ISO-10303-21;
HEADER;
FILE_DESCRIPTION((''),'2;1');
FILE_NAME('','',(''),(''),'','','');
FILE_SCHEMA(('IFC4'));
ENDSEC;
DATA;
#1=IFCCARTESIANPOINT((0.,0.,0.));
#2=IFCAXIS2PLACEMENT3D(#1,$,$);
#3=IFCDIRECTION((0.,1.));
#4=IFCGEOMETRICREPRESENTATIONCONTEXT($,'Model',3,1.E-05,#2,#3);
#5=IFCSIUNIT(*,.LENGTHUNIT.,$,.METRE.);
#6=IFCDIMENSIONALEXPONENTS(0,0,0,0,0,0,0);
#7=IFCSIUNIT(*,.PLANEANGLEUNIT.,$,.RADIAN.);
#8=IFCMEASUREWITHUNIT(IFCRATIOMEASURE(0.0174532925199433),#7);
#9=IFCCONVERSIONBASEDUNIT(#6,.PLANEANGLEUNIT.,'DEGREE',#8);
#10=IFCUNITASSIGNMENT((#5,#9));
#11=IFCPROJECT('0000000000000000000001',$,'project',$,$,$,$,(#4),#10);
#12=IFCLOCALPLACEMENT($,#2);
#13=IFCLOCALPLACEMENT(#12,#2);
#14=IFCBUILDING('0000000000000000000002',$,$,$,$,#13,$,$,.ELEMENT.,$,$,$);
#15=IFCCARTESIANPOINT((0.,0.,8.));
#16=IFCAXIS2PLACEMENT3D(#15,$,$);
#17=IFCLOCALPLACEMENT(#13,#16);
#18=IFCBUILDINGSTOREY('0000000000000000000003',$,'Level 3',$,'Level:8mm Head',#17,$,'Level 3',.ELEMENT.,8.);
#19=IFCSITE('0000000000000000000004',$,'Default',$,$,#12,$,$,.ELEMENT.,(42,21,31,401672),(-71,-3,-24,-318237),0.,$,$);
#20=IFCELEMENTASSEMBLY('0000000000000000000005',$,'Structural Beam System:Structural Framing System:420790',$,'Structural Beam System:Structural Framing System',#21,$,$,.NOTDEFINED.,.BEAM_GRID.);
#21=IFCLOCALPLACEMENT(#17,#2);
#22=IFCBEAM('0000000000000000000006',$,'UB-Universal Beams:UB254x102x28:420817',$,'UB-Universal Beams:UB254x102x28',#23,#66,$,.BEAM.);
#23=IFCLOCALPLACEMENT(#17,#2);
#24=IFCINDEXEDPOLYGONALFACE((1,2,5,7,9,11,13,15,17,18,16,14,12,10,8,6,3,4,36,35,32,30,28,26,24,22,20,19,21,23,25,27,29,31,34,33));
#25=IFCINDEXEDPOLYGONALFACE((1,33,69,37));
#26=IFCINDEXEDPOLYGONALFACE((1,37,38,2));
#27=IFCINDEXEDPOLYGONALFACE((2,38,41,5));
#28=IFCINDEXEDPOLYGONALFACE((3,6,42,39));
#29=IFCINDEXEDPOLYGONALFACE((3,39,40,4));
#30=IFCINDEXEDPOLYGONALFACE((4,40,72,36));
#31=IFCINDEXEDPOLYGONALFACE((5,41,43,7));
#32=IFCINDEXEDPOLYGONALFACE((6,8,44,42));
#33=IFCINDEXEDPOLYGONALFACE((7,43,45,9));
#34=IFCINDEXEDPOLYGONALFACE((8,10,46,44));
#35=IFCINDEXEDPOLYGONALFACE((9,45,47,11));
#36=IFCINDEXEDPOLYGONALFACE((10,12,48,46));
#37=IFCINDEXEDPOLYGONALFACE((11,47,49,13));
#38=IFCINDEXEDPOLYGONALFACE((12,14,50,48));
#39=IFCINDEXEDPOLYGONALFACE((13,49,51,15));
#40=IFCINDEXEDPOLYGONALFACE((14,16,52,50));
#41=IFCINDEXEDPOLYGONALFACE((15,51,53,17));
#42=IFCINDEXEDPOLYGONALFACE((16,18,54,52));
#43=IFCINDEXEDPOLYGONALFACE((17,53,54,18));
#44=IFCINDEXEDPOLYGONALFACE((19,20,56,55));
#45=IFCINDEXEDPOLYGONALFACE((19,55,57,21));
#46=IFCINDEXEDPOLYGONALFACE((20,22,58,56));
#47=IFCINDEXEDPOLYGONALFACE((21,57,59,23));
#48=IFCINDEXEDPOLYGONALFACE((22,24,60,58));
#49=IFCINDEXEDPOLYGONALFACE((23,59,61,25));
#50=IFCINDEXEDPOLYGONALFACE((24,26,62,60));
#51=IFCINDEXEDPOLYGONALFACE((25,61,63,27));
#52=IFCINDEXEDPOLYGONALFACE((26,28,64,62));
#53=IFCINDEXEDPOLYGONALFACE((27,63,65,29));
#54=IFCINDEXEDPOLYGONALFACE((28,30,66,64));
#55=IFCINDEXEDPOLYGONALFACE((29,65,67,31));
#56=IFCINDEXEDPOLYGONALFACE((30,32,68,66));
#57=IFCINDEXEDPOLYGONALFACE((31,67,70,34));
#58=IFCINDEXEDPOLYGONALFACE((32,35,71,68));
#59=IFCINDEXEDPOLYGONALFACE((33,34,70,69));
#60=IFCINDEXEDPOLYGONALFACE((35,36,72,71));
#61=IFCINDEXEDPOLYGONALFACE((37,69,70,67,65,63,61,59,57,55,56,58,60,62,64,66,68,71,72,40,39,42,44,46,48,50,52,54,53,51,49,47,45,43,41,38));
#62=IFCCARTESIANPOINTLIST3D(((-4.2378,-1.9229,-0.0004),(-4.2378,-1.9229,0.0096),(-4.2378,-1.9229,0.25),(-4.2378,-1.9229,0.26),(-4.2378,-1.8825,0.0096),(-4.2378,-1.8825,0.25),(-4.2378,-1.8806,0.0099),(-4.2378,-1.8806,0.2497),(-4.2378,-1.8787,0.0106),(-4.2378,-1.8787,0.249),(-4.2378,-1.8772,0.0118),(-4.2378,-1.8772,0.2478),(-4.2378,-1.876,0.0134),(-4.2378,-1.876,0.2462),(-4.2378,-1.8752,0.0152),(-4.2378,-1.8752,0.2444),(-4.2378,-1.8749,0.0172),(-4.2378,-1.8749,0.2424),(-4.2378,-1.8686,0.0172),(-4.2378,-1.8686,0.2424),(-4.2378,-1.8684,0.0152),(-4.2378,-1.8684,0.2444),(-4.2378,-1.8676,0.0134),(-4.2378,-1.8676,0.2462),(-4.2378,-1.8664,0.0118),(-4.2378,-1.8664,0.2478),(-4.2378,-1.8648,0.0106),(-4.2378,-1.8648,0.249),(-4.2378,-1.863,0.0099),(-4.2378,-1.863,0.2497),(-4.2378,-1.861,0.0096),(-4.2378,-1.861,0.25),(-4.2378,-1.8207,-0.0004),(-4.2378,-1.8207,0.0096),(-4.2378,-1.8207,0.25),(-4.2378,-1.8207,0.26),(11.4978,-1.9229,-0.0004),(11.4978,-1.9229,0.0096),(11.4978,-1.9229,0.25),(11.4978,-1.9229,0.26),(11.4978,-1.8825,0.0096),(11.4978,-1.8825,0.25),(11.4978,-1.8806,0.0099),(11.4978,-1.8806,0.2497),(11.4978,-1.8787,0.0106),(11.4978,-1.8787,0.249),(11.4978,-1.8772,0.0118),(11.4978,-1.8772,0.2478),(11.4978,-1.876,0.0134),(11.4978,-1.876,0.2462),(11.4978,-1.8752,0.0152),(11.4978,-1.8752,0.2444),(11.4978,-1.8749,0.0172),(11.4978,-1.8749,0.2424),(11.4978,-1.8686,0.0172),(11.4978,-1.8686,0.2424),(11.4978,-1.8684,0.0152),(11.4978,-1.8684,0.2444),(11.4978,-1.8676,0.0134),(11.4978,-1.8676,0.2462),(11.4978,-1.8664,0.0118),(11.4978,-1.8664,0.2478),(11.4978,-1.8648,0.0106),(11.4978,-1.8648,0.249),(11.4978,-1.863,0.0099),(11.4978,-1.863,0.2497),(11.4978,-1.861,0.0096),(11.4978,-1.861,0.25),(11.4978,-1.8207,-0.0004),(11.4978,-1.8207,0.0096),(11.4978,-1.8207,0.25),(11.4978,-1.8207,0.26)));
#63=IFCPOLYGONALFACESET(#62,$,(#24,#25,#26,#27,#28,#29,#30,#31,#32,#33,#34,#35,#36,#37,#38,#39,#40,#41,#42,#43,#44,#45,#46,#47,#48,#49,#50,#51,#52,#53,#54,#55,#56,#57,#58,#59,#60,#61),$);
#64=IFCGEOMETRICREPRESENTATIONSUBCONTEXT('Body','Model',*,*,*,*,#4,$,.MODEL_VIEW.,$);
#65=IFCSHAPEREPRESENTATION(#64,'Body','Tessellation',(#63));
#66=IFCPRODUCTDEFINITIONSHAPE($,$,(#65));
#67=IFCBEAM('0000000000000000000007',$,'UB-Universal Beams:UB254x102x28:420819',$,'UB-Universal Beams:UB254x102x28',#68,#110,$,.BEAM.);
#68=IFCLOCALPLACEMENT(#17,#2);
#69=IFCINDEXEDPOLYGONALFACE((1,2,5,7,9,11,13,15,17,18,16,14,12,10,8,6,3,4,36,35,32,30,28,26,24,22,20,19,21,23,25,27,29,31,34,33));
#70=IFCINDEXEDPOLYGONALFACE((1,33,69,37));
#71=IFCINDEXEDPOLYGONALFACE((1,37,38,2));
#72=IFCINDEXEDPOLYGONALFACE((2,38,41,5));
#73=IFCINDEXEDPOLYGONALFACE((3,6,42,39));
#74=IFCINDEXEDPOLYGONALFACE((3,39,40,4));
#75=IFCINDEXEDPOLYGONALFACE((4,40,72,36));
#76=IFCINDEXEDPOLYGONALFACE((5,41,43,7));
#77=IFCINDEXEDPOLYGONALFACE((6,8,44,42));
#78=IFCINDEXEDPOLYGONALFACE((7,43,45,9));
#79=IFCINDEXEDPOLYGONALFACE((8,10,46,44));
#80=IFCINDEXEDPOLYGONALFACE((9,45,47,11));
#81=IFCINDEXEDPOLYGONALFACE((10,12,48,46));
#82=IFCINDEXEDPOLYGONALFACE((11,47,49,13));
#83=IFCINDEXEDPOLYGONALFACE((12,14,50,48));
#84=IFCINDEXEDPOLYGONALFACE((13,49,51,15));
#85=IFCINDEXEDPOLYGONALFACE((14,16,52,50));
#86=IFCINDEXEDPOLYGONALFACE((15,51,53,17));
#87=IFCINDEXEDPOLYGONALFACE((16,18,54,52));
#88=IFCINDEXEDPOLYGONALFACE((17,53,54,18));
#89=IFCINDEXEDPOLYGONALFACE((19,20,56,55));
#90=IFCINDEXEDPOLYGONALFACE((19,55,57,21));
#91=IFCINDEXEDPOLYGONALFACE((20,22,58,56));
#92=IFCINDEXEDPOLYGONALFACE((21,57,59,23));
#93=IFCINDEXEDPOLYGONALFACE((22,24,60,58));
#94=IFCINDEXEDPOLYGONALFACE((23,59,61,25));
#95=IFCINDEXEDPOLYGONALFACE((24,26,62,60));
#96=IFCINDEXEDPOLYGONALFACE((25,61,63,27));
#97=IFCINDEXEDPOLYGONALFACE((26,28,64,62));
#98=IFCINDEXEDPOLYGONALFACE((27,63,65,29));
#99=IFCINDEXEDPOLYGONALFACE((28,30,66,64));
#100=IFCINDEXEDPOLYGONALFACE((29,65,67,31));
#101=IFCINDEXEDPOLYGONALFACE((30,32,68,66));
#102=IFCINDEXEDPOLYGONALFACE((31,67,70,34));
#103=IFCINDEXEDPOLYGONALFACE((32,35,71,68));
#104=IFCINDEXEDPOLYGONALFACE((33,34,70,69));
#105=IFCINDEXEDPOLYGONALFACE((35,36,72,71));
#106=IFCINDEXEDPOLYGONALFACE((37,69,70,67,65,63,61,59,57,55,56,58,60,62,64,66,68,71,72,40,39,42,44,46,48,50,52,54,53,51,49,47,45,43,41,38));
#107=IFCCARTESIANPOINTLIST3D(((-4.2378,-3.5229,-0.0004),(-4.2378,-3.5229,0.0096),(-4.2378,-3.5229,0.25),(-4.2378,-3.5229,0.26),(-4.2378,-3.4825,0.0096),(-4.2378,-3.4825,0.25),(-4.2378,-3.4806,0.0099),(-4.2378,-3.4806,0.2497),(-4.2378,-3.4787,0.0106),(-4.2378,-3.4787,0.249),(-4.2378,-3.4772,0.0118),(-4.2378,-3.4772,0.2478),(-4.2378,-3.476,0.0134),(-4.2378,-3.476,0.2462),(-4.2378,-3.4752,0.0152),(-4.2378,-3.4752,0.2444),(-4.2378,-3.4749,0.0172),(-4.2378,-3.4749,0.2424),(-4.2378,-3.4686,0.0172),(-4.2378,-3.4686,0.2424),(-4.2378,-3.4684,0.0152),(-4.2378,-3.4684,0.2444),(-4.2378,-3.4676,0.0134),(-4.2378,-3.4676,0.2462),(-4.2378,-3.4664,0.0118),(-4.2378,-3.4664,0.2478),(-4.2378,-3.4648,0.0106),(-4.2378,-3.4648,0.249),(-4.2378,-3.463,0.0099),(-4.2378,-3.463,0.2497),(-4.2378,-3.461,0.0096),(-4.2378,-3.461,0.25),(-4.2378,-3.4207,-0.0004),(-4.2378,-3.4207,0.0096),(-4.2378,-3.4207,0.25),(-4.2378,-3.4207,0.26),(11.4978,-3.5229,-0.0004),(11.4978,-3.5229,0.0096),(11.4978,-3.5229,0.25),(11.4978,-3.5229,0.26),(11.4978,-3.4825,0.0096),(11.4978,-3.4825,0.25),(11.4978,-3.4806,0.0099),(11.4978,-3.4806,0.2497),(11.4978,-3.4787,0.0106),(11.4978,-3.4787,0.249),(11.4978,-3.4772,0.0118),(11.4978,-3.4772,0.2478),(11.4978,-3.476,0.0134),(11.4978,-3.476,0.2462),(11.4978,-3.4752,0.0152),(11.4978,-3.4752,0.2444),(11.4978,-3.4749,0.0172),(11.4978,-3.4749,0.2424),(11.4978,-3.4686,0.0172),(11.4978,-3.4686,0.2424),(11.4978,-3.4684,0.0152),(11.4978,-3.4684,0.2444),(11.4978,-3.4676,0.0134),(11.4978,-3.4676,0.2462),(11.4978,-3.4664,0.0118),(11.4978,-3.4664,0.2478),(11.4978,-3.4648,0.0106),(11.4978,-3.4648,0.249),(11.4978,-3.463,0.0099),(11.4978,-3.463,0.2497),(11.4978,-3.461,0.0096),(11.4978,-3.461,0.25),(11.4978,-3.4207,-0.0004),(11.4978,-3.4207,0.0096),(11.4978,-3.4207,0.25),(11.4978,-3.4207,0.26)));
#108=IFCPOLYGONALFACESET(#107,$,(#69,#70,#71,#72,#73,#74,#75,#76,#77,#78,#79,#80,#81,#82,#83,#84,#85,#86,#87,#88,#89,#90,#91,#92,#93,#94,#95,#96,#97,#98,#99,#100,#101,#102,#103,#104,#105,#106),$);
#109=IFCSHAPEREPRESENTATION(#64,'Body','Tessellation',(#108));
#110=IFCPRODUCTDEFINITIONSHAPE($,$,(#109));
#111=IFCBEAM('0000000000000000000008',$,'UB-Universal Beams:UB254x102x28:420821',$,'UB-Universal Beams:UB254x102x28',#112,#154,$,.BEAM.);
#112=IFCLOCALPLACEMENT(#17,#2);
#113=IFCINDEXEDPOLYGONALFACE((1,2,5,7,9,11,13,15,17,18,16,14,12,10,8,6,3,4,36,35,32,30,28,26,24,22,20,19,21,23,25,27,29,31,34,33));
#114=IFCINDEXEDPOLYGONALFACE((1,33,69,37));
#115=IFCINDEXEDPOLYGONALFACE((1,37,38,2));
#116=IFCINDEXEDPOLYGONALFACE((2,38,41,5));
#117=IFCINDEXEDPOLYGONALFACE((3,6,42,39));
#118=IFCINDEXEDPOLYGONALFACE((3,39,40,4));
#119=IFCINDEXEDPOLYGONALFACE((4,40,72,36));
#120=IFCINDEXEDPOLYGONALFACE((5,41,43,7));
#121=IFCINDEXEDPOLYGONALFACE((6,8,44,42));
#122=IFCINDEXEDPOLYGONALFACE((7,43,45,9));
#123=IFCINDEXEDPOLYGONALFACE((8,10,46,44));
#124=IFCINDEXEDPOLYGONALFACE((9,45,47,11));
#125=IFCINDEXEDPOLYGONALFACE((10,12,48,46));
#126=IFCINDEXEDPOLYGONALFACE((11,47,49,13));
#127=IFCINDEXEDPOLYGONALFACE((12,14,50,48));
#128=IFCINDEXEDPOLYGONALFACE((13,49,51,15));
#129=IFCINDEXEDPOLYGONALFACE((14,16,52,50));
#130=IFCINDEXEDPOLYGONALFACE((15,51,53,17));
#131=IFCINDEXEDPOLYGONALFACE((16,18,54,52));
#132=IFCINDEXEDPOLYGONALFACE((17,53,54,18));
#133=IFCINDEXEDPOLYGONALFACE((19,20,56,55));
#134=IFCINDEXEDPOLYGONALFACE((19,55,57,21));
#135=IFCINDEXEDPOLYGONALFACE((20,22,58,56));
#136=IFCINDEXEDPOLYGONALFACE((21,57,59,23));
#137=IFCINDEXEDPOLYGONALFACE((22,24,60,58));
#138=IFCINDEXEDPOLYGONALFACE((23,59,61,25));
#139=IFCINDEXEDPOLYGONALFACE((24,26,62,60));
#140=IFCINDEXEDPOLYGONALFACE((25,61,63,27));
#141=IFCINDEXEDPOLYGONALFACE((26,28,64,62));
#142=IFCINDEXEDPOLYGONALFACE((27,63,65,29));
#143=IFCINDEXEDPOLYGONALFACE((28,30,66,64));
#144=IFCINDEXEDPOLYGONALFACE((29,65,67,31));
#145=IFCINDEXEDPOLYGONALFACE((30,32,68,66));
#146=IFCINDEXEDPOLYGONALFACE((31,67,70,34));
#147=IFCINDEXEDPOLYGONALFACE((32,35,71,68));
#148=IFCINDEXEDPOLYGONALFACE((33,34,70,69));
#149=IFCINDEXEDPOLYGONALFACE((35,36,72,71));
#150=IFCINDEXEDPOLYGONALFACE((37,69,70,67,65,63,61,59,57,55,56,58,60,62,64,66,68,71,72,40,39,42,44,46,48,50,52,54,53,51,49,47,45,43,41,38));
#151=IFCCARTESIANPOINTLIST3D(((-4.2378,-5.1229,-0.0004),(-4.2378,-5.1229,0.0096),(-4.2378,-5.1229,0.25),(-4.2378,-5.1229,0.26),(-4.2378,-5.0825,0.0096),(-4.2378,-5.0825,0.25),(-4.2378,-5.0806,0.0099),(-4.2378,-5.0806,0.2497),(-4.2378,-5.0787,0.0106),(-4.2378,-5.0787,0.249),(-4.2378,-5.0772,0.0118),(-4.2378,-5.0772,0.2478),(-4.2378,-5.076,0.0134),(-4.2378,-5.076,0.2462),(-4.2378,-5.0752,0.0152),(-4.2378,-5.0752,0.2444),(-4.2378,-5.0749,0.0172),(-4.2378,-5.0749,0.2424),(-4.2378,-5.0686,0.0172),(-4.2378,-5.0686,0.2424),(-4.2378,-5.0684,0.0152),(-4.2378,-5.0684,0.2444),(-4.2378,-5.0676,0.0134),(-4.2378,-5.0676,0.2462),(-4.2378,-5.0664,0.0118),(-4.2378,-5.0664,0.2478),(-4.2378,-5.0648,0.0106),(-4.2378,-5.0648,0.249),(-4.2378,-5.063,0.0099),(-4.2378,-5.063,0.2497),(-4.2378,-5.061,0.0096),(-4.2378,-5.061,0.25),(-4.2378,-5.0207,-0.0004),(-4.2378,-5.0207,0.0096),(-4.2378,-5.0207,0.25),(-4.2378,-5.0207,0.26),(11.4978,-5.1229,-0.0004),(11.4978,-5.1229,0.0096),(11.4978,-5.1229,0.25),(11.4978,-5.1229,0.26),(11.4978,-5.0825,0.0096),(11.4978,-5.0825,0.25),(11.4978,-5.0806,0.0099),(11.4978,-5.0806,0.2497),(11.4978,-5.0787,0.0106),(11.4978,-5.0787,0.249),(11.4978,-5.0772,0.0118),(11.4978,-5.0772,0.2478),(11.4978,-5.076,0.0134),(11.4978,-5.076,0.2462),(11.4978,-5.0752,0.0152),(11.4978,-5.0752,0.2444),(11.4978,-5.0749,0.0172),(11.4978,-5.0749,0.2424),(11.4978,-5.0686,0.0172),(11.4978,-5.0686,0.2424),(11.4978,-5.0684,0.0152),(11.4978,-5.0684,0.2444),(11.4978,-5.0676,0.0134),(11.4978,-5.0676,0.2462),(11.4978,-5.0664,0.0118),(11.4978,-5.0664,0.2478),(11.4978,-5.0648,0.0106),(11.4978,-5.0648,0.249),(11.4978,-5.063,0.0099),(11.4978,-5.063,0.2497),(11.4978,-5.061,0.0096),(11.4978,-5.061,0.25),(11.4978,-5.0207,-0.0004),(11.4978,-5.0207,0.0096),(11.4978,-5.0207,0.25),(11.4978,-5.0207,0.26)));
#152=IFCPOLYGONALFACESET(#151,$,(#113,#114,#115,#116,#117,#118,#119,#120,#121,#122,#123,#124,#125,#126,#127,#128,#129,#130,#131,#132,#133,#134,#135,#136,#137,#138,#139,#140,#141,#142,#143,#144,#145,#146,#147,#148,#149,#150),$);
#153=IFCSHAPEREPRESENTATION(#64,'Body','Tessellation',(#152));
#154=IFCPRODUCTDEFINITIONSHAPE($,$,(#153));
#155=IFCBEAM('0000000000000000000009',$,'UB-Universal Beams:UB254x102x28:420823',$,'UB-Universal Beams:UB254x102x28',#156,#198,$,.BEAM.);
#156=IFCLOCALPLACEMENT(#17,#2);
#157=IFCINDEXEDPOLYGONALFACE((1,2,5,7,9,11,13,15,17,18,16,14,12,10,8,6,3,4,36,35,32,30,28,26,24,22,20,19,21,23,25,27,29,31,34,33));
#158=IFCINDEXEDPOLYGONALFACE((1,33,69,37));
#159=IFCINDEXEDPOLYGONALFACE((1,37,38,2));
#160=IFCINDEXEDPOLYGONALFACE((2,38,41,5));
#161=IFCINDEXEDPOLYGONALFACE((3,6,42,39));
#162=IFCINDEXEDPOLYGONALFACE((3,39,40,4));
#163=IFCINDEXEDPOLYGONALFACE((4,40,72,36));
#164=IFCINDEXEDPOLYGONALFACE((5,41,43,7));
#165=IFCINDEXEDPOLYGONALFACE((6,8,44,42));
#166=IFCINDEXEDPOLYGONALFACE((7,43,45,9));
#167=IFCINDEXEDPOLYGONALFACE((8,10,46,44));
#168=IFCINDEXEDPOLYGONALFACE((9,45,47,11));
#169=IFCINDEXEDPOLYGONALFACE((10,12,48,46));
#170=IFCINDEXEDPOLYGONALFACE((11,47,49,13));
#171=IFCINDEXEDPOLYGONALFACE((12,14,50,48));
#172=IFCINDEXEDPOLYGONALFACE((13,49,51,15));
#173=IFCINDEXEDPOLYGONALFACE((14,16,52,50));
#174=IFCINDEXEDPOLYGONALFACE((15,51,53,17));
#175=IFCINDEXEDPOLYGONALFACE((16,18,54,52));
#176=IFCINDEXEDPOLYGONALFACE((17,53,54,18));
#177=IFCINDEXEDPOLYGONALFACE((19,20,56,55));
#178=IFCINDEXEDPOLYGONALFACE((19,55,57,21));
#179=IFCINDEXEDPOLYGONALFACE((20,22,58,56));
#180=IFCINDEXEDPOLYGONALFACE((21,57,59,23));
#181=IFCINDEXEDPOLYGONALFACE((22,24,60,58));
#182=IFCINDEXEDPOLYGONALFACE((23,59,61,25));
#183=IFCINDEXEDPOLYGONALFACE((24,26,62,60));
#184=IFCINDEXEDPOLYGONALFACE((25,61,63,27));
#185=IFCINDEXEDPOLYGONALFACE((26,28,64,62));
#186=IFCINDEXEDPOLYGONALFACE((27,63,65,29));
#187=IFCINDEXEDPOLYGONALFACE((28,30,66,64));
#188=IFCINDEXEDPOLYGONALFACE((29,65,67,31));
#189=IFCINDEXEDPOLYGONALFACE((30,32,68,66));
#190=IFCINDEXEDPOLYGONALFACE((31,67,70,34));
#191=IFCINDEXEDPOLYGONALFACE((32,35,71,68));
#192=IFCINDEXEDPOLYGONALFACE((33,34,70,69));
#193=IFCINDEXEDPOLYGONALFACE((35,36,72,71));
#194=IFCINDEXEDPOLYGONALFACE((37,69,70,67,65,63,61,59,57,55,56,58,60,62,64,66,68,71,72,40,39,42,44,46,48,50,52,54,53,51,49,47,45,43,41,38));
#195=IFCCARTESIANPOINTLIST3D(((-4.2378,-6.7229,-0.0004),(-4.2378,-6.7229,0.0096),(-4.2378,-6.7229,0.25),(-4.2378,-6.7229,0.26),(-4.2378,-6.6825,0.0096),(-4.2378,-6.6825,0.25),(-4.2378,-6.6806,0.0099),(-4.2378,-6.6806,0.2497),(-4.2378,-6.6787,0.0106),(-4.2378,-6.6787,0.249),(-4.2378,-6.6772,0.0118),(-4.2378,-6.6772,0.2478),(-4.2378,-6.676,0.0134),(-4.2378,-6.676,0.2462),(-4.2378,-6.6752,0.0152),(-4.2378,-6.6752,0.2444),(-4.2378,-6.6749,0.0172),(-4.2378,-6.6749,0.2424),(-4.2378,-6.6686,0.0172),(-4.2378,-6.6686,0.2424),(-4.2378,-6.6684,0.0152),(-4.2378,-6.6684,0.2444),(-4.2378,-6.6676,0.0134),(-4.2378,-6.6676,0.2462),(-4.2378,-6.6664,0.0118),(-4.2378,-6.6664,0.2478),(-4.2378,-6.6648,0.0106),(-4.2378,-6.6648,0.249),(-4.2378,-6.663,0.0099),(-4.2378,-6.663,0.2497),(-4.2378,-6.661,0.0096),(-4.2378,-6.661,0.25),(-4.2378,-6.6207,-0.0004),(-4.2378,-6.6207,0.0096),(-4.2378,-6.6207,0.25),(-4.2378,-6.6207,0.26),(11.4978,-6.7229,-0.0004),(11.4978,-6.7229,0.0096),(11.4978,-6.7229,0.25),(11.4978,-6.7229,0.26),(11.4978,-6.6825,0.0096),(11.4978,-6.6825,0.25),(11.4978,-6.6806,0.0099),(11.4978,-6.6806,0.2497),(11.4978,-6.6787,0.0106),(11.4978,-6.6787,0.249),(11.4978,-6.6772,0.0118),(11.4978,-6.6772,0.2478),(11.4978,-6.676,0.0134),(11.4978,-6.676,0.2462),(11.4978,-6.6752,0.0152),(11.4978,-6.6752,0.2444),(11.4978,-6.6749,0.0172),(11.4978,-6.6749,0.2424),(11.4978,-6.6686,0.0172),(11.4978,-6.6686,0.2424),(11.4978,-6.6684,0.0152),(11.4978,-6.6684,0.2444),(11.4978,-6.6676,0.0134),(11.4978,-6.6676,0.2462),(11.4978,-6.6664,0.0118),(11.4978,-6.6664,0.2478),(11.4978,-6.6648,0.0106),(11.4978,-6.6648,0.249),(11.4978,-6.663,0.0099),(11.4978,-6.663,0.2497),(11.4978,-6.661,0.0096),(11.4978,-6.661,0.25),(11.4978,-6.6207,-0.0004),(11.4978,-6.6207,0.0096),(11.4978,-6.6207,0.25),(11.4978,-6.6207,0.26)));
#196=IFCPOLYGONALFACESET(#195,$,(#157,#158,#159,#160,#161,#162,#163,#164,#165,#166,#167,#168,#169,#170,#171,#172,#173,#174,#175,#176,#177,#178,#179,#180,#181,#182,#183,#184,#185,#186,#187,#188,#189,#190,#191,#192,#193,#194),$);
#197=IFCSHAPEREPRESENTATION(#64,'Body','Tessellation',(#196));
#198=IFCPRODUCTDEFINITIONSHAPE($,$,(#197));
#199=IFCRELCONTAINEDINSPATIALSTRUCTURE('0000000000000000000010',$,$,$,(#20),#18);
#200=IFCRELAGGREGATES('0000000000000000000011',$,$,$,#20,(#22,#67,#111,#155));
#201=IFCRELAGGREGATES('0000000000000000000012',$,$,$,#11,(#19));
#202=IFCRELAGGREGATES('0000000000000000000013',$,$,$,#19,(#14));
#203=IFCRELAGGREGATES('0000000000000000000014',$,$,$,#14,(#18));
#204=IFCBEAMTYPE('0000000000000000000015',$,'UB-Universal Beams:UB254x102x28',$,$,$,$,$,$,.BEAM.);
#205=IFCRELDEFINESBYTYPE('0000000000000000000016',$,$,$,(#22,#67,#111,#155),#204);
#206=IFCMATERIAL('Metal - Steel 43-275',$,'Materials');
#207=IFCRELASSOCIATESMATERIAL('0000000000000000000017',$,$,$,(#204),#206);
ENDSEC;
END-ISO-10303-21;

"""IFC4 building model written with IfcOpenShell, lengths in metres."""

from ifc_helpers import new_model, entity, si_unit, converted_unit, direction, frame, frame_2d, origin, place, context, subcontext, project, spatial, i_section, extrude, source, transform, mapped, material, material_profile, profile_set, type_object, type_shapes, element, aggregate, save


model = new_model("IFC4")

# Units and contexts
model_context = context("Model", 3, precision=1e-05, world=origin(), true_north=direction((0.0, 1.0)))
body_context = subcontext(model_context, "Body", "Model", "MODEL_VIEW")
ifc_project = project(units=[si_unit("LENGTHUNIT", "METRE"), converted_unit("PLANEANGLEUNIT", "DEGREE", entity("IfcRatioMeasure", 0.0174532925199433), si_unit("PLANEANGLEUNIT", "RADIAN"), dimensions=[0, 0, 0, 0, 0, 0, 0])], contexts=[model_context])

# Site, building, storey
site_placement = place(None, origin())
site = spatial("IfcSite", under=ifc_project, at=site_placement, Name="Default", CompositionType="ELEMENT", RefLatitude=(42, 21, 31, 401672), RefLongitude=(-71, -3, -24, -318237), RefElevation=0.0)
building_placement = place(site_placement, origin())
building = spatial("IfcBuilding", under=site, at=building_placement, CompositionType="ELEMENT")
storey_placement = place(building_placement, frame((0.0, 0.0, 8.0)))
storey = spatial("IfcBuildingStorey", under=building, at=storey_placement, Name="Level 3", ObjectType="Level:8mm Head", LongName="Level 3", CompositionType="ELEMENT", Elevation=8.0)

# Shared definitions
ifc_material_1 = material(Name="Metal - Steel 43-275", Category="Materials")

# Element assembly, beams
assembly_placement = place(storey_placement, origin())
assembly = element("IfcElementAssembly", 1, at=assembly_placement, inside=storey, Name="Structural Beam System:Structural Framing System:420790", ObjectType="Structural Beam System:Structural Framing System", AssemblyPlace="NOTDEFINED", PredefinedType="BEAM_GRID")
ifc_material_profile_1 = material_profile(ifc_material_1, i_section(OverallWidth=0.1022, OverallDepth=0.2604, WebThickness=0.0063, FlangeThickness=0.01, FilletRadius=0.0076, at=frame_2d((0.0, 0.0), x_axis=(0.0, 1.0))), Name="UB254x102x28")
ifc_profile_set_1 = profile_set([ifc_material_profile_1], Name="UB254x102x28")
beam_type_1 = type_object("IfcBeamType", Name="UB-Universal Beams:UB254x102x28", PredefinedType="BEAM", material=ifc_profile_set_1)
shared_shape_1 = source(origin(), body_context, "Body", "SweptSolid", [
    extrude(i_section(OverallWidth=0.1022, OverallDepth=0.2604, WebThickness=0.0063, FlangeThickness=0.01, FilletRadius=0.0076, at=frame_2d((0.0, 0.0), x_axis=(0.0, 1.0))), frame((-7.8373, 0.0, 0.0), z_axis=(1.0, 0.0, 0.0), x_axis=(0.0, 0.0, -1.0)), (0.0, 0.0, 1.0), 15.7356),
])
type_shapes(beam_type_1, [shared_shape_1])
beam_1_placement = place(assembly_placement, frame((3.5995, -1.8718, 0.1298)))
beam_1 = element("IfcBeam", 2, at=beam_1_placement, type_object=beam_type_1, Name="UB-Universal Beams:UB254x102x28:420817", ObjectType="UB-Universal Beams:UB254x102x28", PredefinedType="BEAM", context=body_context, shape_type="MappedRepresentation", body=[
    mapped(shared_shape_1, transform((0.0, 0.0, 0.0), scale=1.0)),
])
beam_2_placement = place(assembly_placement, frame((3.5995, -3.4718, 0.1298)))
beam_2 = element("IfcBeam", 3, at=beam_2_placement, type_object=beam_type_1, Name="UB-Universal Beams:UB254x102x28:420819", ObjectType="UB-Universal Beams:UB254x102x28", PredefinedType="BEAM", context=body_context, shape_type="MappedRepresentation", body=[
    mapped(shared_shape_1, transform((0.0, 0.0, 0.0), scale=1.0)),
])
beam_3_placement = place(assembly_placement, frame((3.5995, -5.0718, 0.1298)))
beam_3 = element("IfcBeam", 4, at=beam_3_placement, type_object=beam_type_1, Name="UB-Universal Beams:UB254x102x28:420821", ObjectType="UB-Universal Beams:UB254x102x28", PredefinedType="BEAM", context=body_context, shape_type="MappedRepresentation", body=[
    mapped(shared_shape_1, transform((0.0, 0.0, 0.0), scale=1.0)),
])
beam_4_placement = place(assembly_placement, frame((3.5995, -6.6718, 0.1298)))
beam_4 = element("IfcBeam", 5, at=beam_4_placement, type_object=beam_type_1, Name="UB-Universal Beams:UB254x102x28:420823", ObjectType="UB-Universal Beams:UB254x102x28", PredefinedType="BEAM", context=body_context, shape_type="MappedRepresentation", body=[
    mapped(shared_shape_1, transform((0.0, 0.0, 0.0), scale=1.0)),
])
aggregate(assembly, [beam_1, beam_2, beam_3, beam_4])

save(model, "model.ifc")
